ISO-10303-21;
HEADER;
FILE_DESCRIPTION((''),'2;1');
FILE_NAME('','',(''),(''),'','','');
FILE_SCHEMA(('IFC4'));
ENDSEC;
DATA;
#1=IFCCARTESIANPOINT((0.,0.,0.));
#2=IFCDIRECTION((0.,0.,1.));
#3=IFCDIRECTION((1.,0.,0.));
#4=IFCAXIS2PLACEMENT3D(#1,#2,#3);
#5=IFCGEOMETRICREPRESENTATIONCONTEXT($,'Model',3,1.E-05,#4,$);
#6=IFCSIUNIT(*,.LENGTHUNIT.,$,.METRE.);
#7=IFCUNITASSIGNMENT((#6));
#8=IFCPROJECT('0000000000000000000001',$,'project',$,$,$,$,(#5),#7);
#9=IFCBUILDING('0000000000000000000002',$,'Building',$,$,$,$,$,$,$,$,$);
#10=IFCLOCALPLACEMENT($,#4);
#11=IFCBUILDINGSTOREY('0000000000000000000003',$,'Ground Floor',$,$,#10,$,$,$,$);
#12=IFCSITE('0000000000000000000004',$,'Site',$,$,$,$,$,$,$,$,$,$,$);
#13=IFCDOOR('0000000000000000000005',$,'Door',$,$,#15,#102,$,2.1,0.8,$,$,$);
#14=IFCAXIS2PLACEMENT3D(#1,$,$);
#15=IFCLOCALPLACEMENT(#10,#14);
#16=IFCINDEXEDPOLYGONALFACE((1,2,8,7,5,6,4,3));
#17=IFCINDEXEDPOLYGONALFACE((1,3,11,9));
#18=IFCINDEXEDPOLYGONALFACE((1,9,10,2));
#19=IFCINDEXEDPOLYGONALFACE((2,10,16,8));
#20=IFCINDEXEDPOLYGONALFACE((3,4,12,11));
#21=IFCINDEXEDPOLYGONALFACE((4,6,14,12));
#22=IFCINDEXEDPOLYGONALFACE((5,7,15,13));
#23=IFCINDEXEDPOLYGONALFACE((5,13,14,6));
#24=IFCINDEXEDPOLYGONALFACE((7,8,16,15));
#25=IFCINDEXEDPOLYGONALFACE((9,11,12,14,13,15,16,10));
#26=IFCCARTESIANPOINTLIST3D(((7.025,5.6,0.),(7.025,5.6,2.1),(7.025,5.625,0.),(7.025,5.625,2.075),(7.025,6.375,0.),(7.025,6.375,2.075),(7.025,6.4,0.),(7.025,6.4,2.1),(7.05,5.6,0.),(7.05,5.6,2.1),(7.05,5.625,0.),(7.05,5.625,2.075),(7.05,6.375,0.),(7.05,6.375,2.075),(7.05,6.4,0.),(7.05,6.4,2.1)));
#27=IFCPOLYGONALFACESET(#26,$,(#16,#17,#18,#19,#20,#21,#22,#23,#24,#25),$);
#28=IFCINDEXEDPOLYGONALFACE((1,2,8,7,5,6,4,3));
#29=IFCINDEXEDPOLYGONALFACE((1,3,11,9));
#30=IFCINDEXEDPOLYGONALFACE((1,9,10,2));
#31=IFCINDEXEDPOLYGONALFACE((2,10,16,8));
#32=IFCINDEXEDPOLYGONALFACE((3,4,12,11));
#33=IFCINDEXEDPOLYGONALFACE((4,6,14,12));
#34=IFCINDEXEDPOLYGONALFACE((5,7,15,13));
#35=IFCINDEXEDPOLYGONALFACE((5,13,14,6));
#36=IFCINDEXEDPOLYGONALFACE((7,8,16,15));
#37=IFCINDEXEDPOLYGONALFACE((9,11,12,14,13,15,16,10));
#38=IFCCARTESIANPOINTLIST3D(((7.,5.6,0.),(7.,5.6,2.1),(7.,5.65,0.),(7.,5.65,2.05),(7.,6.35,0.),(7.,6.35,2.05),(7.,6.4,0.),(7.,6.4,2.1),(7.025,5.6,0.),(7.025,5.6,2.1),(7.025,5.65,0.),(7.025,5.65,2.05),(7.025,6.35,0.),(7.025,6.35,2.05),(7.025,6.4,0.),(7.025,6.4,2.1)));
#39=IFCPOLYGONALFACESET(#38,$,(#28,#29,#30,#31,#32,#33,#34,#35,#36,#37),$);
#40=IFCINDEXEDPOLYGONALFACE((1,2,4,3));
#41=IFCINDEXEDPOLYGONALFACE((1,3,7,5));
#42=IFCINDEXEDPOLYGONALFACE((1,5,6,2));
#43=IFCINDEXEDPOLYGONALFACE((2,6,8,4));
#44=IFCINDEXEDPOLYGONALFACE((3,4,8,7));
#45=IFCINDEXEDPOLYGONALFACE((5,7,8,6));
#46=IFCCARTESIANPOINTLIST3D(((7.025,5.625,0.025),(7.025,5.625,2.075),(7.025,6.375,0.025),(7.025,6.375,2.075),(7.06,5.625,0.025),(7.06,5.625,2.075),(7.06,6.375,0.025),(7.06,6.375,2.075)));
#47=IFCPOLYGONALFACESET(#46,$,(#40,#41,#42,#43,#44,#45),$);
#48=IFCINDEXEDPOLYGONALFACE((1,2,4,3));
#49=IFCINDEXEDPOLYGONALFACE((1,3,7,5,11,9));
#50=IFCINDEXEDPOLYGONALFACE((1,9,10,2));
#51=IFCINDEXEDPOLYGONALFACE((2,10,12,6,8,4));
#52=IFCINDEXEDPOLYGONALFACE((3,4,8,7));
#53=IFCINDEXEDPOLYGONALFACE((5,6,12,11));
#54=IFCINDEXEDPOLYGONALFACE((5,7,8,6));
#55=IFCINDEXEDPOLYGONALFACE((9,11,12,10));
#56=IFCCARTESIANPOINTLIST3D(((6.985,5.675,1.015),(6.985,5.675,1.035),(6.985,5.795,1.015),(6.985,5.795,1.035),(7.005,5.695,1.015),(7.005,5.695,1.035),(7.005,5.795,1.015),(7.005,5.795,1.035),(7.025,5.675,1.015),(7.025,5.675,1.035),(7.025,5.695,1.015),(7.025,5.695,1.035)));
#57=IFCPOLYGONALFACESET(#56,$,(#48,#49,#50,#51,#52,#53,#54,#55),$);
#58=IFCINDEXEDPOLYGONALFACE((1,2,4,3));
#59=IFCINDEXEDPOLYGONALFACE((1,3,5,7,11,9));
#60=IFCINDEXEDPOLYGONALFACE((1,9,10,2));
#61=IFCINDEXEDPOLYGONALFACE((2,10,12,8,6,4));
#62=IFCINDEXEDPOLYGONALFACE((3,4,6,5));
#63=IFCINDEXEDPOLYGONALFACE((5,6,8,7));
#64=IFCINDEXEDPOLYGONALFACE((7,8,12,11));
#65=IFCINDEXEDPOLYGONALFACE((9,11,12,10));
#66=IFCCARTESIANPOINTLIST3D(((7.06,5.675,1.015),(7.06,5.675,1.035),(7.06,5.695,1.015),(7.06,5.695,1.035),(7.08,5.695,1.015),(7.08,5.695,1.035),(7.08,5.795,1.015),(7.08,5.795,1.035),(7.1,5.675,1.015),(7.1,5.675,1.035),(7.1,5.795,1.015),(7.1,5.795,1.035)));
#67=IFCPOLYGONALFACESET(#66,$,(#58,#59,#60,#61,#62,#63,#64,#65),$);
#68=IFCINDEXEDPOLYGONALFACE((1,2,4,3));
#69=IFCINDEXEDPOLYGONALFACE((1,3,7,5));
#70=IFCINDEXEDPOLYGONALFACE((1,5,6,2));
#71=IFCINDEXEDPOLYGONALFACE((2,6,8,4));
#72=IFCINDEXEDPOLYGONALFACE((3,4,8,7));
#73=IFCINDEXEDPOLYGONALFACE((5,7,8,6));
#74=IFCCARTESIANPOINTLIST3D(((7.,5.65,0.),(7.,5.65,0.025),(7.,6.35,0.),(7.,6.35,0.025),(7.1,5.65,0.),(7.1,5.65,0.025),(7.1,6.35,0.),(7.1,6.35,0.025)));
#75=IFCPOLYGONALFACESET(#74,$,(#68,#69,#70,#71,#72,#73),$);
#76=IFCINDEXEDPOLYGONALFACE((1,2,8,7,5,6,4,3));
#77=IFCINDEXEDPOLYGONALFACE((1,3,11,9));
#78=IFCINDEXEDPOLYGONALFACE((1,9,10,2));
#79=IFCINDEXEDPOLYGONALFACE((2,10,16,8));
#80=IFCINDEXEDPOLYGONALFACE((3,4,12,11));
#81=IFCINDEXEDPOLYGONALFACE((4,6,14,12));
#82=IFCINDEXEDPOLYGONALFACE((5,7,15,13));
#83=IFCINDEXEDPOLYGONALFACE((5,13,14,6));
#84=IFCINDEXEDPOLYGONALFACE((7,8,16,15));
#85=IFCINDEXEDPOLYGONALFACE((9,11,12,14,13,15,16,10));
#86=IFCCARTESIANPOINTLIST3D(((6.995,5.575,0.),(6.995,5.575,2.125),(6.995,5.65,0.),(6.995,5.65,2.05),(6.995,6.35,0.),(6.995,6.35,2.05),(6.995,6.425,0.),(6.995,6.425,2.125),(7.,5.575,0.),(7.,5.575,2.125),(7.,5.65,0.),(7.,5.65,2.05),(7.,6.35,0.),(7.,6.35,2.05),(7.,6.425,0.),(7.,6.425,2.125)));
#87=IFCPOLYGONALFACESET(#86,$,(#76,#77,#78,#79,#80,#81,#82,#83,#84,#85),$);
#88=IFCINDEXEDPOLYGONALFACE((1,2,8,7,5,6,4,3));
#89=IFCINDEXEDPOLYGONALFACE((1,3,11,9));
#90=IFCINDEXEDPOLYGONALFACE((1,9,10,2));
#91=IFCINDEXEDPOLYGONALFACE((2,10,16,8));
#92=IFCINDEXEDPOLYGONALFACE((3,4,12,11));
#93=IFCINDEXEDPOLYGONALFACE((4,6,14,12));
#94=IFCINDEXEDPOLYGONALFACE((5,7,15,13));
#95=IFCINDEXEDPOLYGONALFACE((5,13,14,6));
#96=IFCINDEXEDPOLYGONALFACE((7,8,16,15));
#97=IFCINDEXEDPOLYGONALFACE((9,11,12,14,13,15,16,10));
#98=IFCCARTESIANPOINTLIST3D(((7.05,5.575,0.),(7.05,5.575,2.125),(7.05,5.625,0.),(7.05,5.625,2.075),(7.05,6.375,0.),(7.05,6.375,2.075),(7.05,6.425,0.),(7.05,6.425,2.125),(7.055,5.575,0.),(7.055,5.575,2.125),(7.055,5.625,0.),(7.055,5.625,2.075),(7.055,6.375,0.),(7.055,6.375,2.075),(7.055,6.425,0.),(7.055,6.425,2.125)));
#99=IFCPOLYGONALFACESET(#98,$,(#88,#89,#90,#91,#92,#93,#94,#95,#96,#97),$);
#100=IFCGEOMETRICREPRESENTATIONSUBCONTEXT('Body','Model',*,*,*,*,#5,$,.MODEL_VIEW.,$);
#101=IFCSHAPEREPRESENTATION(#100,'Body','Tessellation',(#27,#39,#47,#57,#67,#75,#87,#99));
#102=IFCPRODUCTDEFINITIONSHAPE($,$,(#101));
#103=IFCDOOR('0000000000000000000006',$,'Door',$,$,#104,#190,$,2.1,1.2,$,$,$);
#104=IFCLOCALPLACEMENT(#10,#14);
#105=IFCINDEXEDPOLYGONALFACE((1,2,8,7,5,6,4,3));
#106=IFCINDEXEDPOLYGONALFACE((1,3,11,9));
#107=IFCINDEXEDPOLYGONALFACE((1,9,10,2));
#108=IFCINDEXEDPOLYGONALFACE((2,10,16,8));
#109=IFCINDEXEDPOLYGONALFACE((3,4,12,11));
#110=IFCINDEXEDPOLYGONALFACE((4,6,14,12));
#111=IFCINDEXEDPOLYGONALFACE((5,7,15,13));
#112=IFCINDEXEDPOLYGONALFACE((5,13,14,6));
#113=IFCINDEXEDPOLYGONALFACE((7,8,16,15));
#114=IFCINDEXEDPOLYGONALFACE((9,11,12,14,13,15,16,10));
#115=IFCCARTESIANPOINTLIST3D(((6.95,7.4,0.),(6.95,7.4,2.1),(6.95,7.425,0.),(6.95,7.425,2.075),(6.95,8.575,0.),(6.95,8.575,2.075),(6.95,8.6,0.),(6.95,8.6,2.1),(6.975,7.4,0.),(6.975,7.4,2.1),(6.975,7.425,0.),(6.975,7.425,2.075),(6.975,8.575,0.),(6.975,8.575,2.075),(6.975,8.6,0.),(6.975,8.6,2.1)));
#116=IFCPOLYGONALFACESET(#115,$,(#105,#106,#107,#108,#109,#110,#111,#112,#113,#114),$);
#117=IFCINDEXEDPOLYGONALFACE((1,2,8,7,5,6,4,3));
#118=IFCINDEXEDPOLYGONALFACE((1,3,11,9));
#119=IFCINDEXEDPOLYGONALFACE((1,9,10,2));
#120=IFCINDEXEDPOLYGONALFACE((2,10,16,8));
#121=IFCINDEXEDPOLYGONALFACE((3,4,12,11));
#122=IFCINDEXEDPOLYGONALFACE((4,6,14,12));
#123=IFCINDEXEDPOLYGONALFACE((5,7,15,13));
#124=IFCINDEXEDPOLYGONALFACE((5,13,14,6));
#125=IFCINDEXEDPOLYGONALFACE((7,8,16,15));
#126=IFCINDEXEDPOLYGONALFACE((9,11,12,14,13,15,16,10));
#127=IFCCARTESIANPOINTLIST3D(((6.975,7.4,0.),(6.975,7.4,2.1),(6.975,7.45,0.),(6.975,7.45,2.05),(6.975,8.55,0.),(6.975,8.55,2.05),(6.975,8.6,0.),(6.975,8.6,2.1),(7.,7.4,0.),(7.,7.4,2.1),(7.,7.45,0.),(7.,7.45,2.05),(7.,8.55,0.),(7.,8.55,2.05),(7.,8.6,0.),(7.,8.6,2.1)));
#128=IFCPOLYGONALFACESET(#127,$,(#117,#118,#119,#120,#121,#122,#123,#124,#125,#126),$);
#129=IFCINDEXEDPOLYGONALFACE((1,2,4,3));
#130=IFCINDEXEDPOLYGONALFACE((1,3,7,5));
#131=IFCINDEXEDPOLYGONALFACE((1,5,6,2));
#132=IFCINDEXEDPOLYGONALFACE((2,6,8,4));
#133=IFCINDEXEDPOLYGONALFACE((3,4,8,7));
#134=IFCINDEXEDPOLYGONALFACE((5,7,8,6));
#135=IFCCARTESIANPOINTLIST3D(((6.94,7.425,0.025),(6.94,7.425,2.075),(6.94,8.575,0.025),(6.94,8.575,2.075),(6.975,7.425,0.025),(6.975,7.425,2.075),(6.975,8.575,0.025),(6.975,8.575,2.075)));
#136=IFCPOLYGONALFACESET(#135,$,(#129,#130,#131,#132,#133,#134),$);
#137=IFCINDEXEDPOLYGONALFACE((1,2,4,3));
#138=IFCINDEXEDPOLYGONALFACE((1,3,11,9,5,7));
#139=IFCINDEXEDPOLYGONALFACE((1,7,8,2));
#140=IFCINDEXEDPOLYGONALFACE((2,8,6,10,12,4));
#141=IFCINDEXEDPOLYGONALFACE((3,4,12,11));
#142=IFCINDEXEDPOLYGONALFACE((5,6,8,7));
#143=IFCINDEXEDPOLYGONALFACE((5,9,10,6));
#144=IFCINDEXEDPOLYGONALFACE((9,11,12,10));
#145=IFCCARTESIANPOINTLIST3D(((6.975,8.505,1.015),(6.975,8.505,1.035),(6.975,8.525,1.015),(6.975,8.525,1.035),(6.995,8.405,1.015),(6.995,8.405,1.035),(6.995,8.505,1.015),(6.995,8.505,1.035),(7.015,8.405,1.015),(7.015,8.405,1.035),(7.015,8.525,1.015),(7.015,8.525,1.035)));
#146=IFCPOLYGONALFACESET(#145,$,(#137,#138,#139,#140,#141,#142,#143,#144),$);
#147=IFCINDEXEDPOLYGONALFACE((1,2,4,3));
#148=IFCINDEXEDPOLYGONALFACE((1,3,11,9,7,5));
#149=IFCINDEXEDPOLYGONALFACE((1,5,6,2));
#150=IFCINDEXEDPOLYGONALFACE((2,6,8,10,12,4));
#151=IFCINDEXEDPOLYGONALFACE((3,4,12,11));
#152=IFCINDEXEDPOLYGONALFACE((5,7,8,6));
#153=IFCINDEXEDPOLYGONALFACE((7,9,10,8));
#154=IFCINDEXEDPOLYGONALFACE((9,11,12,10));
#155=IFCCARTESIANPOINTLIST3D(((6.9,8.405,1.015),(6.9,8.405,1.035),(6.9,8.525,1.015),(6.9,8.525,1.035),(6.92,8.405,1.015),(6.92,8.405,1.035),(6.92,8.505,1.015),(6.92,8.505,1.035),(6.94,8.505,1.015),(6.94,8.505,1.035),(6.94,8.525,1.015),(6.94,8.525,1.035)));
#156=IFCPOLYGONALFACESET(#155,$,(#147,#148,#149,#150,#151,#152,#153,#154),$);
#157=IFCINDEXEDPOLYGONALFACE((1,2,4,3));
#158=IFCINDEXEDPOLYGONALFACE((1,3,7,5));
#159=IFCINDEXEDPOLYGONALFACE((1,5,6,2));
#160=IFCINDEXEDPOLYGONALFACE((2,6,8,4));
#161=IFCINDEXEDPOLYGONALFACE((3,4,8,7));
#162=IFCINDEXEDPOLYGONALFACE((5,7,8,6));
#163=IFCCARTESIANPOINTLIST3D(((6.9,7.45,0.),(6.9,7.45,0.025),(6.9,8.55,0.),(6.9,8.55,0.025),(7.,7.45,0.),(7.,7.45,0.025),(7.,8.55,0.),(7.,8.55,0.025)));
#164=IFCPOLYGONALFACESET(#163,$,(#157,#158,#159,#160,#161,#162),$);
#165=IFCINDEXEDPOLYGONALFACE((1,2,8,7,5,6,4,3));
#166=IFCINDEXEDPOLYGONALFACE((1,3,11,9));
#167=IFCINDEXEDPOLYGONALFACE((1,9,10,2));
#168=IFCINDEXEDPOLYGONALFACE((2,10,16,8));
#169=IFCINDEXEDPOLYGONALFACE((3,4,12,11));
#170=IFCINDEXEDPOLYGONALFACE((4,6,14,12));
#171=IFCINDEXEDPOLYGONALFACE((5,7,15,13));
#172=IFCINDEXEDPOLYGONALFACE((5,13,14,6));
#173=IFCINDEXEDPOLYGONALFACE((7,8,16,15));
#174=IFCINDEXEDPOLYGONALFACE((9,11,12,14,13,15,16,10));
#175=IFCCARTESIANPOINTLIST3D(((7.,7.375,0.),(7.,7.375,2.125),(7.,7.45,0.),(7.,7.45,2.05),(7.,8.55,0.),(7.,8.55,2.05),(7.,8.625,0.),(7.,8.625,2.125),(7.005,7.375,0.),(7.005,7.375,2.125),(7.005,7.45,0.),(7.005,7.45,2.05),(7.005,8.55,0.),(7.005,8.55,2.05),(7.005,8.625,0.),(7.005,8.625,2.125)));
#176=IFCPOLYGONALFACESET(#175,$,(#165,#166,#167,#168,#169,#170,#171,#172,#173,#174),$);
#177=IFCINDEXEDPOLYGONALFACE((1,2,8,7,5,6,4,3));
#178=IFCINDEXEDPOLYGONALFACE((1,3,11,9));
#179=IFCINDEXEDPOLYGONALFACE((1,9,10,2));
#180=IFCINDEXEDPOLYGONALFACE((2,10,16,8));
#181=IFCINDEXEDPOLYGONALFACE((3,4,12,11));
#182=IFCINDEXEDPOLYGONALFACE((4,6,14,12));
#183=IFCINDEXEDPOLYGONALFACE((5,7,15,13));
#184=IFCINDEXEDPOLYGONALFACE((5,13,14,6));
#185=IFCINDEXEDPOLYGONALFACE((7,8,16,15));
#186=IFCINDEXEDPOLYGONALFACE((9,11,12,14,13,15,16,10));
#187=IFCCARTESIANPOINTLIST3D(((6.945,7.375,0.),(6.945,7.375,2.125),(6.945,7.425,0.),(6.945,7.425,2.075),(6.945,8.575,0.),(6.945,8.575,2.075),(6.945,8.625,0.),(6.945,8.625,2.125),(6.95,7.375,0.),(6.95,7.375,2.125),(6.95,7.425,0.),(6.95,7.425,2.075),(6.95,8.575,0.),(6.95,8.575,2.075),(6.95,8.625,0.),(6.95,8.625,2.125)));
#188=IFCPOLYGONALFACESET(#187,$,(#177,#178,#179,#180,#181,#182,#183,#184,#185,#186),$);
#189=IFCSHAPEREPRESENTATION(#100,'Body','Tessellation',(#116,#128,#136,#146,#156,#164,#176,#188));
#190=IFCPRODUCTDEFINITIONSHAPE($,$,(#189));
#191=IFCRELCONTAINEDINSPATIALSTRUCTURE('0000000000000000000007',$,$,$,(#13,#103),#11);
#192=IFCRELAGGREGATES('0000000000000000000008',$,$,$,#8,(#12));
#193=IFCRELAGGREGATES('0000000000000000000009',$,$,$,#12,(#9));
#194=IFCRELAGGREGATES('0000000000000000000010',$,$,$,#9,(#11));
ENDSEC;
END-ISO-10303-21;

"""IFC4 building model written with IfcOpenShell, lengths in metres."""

from ifc_helpers import new_model, si_unit, frame, origin_with_axes, place, context, subcontext, project, spatial, line, indexed_curve, outline, extrude, element, save


model = new_model("IFC4")

# Units and contexts
model_context = context("Model", 3, precision=1e-05, world=origin_with_axes())
body_context = subcontext(model_context, "Body", "Model", "MODEL_VIEW")
ifc_project = project(units=[si_unit("LENGTHUNIT", "METRE")], contexts=[model_context])

# Site, building, storey
site = spatial("IfcSite", under=ifc_project, Name="Site")
building = spatial("IfcBuilding", under=site, Name="Building")
storey_placement = place(None, origin_with_axes())
storey = spatial("IfcBuildingStorey", under=building, at=storey_placement, Name="Ground Floor")

# Doors
door_1_placement = place(storey_placement, frame((7.0, 6.4, 0.0), z_axis=(0.0, 0.0, 1.0), x_axis=(0.0, -1.0, 0.0)))
element("IfcDoor", 1, at=door_1_placement, inside=storey, Name="Door", OverallHeight=2.1, OverallWidth=0.8, context=body_context, shape_type="SweptSolid", body=[
    extrude(outline(indexed_curve([(0.0, 0.0), (0.0, 2.1), (0.8, 2.1), (0.8, 0.0), (0.775, 0.0), (0.775, 2.075), (0.025, 2.075), (0.025, 0.0)], segments=[line(1, 2, 3, 4, 5, 6, 7, 8, 1)])), frame((0.0, 0.025, 0.0), z_axis=(0.0, -1.0, 0.0), x_axis=(1.0, 0.0, 0.0)), (0.0, 0.0, -1.0), 0.025),
    extrude(outline(indexed_curve([(0.0, 0.0), (0.0, 2.1), (0.8, 2.1), (0.8, 0.0), (0.75, 0.0), (0.75, 2.05), (0.05, 2.05), (0.05, 0.0)], segments=[line(1, 2, 3, 4, 5, 6, 7, 8, 1)])), frame((0.0, 0.0, 0.0), z_axis=(0.0, -1.0, 0.0), x_axis=(1.0, 0.0, 0.0)), (0.0, 0.0, -1.0), 0.025),
    extrude(outline(indexed_curve([(0.0, 0.0), (0.75, 0.0), (0.75, 0.035), (0.0, 0.035)], segments=[line(1, 2, 3, 4, 1)])), frame((0.025, 0.025, 0.025), z_axis=(0.0, 0.0, 1.0), x_axis=(1.0, 0.0, 0.0)), (0.0, 0.0, 1.0), 2.05),
    extrude(outline(indexed_curve([(0.0, 0.0), (0.0, -0.04), (-0.12, -0.04), (-0.12, -0.02), (-0.02, -0.02), (-0.02, 0.0)], segments=[line(1, 2, 3, 4, 5, 6, 1)])), frame((0.725, 0.025, 1.015), z_axis=(0.0, 0.0, 1.0), x_axis=(1.0, 0.0, 0.0)), (0.0, 0.0, 1.0), 0.02),
    extrude(outline(indexed_curve([(0.0, 0.0), (0.0, 0.04), (-0.12, 0.04), (-0.12, 0.02), (-0.02, 0.02), (-0.02, 0.0)], segments=[line(1, 2, 3, 4, 5, 6, 1)])), frame((0.725, 0.06, 1.015), z_axis=(0.0, 0.0, 1.0), x_axis=(1.0, 0.0, 0.0)), (0.0, 0.0, 1.0), 0.02),
    extrude(outline(indexed_curve([(0.0, 0.0), (0.7, 0.0), (0.7, 0.1), (0.0, 0.1)], segments=[line(1, 2, 3, 4, 1)])), frame((0.05, 0.0, 0.0), z_axis=(0.0, 0.0, 1.0), x_axis=(1.0, 0.0, 0.0)), (0.0, 0.0, 1.0), 0.025),
    extrude(outline(indexed_curve([(0.0, 0.0), (0.0, 2.125), (0.85, 2.125), (0.85, 0.0), (0.775, 0.0), (0.775, 2.05), (0.075, 2.05), (0.075, 0.0)], segments=[line(1, 2, 3, 4, 5, 6, 7, 8, 1)])), frame((-0.025, -0.005, 0.0), z_axis=(0.0, -1.0, 0.0), x_axis=(1.0, 0.0, 0.0)), (0.0, 0.0, -1.0), 0.005),
    extrude(outline(indexed_curve([(0.0, 0.0), (0.0, 2.125), (0.85, 2.125), (0.85, 0.0), (0.8, 0.0), (0.8, 2.075), (0.05, 2.075), (0.05, 0.0)], segments=[line(1, 2, 3, 4, 5, 6, 7, 8, 1)])), frame((-0.025, 0.05, 0.0), z_axis=(0.0, -1.0, 0.0), x_axis=(1.0, 0.0, 0.0)), (0.0, 0.0, -1.0), 0.005),
])
door_2_placement = place(storey_placement, frame((7.0, 7.4, 0.0), z_axis=(0.0, 0.0, 1.0), x_axis=(0.0, 1.0, 0.0)))
element("IfcDoor", 2, at=door_2_placement, inside=storey, Name="Door", OverallHeight=2.1, OverallWidth=1.2, context=body_context, shape_type="SweptSolid", body=[
    extrude(outline(indexed_curve([(0.0, 0.0), (0.0, 2.1), (1.2, 2.1), (1.2, 0.0), (1.175, 0.0), (1.175, 2.075), (0.025, 2.075), (0.025, 0.0)], segments=[line(1, 2, 3, 4, 5, 6, 7, 8, 1)])), frame((0.0, 0.025, 0.0), z_axis=(0.0, -1.0, 0.0), x_axis=(1.0, 0.0, 0.0)), (0.0, 0.0, -1.0), 0.025),
    extrude(outline(indexed_curve([(0.0, 0.0), (0.0, 2.1), (1.2, 2.1), (1.2, 0.0), (1.15, 0.0), (1.15, 2.05), (0.05, 2.05), (0.05, 0.0)], segments=[line(1, 2, 3, 4, 5, 6, 7, 8, 1)])), frame((0.0, 0.0, 0.0), z_axis=(0.0, -1.0, 0.0), x_axis=(1.0, 0.0, 0.0)), (0.0, 0.0, -1.0), 0.025),
    extrude(outline(indexed_curve([(0.0, 0.0), (1.15, 0.0), (1.15, 0.035), (0.0, 0.035)], segments=[line(1, 2, 3, 4, 1)])), frame((0.025, 0.025, 0.025), z_axis=(0.0, 0.0, 1.0), x_axis=(1.0, 0.0, 0.0)), (0.0, 0.0, 1.0), 2.05),
    extrude(outline(indexed_curve([(0.0, 0.0), (0.0, -0.04), (-0.12, -0.04), (-0.12, -0.02), (-0.02, -0.02), (-0.02, 0.0)], segments=[line(1, 2, 3, 4, 5, 6, 1)])), frame((1.125, 0.025, 1.015), z_axis=(0.0, 0.0, 1.0), x_axis=(1.0, 0.0, 0.0)), (0.0, 0.0, 1.0), 0.02),
    extrude(outline(indexed_curve([(0.0, 0.0), (0.0, 0.04), (-0.12, 0.04), (-0.12, 0.02), (-0.02, 0.02), (-0.02, 0.0)], segments=[line(1, 2, 3, 4, 5, 6, 1)])), frame((1.125, 0.06, 1.015), z_axis=(0.0, 0.0, 1.0), x_axis=(1.0, 0.0, 0.0)), (0.0, 0.0, 1.0), 0.02),
    extrude(outline(indexed_curve([(0.0, 0.0), (1.1, 0.0), (1.1, 0.1), (0.0, 0.1)], segments=[line(1, 2, 3, 4, 1)])), frame((0.05, 0.0, 0.0), z_axis=(0.0, 0.0, 1.0), x_axis=(1.0, 0.0, 0.0)), (0.0, 0.0, 1.0), 0.025),
    extrude(outline(indexed_curve([(0.0, 0.0), (0.0, 2.125), (1.25, 2.125), (1.25, 0.0), (1.175, 0.0), (1.175, 2.05), (0.075, 2.05), (0.075, 0.0)], segments=[line(1, 2, 3, 4, 5, 6, 7, 8, 1)])), frame((-0.025, -0.005, 0.0), z_axis=(0.0, -1.0, 0.0), x_axis=(1.0, 0.0, 0.0)), (0.0, 0.0, -1.0), 0.005),
    extrude(outline(indexed_curve([(0.0, 0.0), (0.0, 2.125), (1.25, 2.125), (1.25, 0.0), (1.2, 0.0), (1.2, 2.075), (0.05, 2.075), (0.05, 0.0)], segments=[line(1, 2, 3, 4, 5, 6, 7, 8, 1)])), frame((-0.025, 0.05, 0.0), z_axis=(0.0, -1.0, 0.0), x_axis=(1.0, 0.0, 0.0)), (0.0, 0.0, -1.0), 0.005),
])

save(model, "model.ifc")
